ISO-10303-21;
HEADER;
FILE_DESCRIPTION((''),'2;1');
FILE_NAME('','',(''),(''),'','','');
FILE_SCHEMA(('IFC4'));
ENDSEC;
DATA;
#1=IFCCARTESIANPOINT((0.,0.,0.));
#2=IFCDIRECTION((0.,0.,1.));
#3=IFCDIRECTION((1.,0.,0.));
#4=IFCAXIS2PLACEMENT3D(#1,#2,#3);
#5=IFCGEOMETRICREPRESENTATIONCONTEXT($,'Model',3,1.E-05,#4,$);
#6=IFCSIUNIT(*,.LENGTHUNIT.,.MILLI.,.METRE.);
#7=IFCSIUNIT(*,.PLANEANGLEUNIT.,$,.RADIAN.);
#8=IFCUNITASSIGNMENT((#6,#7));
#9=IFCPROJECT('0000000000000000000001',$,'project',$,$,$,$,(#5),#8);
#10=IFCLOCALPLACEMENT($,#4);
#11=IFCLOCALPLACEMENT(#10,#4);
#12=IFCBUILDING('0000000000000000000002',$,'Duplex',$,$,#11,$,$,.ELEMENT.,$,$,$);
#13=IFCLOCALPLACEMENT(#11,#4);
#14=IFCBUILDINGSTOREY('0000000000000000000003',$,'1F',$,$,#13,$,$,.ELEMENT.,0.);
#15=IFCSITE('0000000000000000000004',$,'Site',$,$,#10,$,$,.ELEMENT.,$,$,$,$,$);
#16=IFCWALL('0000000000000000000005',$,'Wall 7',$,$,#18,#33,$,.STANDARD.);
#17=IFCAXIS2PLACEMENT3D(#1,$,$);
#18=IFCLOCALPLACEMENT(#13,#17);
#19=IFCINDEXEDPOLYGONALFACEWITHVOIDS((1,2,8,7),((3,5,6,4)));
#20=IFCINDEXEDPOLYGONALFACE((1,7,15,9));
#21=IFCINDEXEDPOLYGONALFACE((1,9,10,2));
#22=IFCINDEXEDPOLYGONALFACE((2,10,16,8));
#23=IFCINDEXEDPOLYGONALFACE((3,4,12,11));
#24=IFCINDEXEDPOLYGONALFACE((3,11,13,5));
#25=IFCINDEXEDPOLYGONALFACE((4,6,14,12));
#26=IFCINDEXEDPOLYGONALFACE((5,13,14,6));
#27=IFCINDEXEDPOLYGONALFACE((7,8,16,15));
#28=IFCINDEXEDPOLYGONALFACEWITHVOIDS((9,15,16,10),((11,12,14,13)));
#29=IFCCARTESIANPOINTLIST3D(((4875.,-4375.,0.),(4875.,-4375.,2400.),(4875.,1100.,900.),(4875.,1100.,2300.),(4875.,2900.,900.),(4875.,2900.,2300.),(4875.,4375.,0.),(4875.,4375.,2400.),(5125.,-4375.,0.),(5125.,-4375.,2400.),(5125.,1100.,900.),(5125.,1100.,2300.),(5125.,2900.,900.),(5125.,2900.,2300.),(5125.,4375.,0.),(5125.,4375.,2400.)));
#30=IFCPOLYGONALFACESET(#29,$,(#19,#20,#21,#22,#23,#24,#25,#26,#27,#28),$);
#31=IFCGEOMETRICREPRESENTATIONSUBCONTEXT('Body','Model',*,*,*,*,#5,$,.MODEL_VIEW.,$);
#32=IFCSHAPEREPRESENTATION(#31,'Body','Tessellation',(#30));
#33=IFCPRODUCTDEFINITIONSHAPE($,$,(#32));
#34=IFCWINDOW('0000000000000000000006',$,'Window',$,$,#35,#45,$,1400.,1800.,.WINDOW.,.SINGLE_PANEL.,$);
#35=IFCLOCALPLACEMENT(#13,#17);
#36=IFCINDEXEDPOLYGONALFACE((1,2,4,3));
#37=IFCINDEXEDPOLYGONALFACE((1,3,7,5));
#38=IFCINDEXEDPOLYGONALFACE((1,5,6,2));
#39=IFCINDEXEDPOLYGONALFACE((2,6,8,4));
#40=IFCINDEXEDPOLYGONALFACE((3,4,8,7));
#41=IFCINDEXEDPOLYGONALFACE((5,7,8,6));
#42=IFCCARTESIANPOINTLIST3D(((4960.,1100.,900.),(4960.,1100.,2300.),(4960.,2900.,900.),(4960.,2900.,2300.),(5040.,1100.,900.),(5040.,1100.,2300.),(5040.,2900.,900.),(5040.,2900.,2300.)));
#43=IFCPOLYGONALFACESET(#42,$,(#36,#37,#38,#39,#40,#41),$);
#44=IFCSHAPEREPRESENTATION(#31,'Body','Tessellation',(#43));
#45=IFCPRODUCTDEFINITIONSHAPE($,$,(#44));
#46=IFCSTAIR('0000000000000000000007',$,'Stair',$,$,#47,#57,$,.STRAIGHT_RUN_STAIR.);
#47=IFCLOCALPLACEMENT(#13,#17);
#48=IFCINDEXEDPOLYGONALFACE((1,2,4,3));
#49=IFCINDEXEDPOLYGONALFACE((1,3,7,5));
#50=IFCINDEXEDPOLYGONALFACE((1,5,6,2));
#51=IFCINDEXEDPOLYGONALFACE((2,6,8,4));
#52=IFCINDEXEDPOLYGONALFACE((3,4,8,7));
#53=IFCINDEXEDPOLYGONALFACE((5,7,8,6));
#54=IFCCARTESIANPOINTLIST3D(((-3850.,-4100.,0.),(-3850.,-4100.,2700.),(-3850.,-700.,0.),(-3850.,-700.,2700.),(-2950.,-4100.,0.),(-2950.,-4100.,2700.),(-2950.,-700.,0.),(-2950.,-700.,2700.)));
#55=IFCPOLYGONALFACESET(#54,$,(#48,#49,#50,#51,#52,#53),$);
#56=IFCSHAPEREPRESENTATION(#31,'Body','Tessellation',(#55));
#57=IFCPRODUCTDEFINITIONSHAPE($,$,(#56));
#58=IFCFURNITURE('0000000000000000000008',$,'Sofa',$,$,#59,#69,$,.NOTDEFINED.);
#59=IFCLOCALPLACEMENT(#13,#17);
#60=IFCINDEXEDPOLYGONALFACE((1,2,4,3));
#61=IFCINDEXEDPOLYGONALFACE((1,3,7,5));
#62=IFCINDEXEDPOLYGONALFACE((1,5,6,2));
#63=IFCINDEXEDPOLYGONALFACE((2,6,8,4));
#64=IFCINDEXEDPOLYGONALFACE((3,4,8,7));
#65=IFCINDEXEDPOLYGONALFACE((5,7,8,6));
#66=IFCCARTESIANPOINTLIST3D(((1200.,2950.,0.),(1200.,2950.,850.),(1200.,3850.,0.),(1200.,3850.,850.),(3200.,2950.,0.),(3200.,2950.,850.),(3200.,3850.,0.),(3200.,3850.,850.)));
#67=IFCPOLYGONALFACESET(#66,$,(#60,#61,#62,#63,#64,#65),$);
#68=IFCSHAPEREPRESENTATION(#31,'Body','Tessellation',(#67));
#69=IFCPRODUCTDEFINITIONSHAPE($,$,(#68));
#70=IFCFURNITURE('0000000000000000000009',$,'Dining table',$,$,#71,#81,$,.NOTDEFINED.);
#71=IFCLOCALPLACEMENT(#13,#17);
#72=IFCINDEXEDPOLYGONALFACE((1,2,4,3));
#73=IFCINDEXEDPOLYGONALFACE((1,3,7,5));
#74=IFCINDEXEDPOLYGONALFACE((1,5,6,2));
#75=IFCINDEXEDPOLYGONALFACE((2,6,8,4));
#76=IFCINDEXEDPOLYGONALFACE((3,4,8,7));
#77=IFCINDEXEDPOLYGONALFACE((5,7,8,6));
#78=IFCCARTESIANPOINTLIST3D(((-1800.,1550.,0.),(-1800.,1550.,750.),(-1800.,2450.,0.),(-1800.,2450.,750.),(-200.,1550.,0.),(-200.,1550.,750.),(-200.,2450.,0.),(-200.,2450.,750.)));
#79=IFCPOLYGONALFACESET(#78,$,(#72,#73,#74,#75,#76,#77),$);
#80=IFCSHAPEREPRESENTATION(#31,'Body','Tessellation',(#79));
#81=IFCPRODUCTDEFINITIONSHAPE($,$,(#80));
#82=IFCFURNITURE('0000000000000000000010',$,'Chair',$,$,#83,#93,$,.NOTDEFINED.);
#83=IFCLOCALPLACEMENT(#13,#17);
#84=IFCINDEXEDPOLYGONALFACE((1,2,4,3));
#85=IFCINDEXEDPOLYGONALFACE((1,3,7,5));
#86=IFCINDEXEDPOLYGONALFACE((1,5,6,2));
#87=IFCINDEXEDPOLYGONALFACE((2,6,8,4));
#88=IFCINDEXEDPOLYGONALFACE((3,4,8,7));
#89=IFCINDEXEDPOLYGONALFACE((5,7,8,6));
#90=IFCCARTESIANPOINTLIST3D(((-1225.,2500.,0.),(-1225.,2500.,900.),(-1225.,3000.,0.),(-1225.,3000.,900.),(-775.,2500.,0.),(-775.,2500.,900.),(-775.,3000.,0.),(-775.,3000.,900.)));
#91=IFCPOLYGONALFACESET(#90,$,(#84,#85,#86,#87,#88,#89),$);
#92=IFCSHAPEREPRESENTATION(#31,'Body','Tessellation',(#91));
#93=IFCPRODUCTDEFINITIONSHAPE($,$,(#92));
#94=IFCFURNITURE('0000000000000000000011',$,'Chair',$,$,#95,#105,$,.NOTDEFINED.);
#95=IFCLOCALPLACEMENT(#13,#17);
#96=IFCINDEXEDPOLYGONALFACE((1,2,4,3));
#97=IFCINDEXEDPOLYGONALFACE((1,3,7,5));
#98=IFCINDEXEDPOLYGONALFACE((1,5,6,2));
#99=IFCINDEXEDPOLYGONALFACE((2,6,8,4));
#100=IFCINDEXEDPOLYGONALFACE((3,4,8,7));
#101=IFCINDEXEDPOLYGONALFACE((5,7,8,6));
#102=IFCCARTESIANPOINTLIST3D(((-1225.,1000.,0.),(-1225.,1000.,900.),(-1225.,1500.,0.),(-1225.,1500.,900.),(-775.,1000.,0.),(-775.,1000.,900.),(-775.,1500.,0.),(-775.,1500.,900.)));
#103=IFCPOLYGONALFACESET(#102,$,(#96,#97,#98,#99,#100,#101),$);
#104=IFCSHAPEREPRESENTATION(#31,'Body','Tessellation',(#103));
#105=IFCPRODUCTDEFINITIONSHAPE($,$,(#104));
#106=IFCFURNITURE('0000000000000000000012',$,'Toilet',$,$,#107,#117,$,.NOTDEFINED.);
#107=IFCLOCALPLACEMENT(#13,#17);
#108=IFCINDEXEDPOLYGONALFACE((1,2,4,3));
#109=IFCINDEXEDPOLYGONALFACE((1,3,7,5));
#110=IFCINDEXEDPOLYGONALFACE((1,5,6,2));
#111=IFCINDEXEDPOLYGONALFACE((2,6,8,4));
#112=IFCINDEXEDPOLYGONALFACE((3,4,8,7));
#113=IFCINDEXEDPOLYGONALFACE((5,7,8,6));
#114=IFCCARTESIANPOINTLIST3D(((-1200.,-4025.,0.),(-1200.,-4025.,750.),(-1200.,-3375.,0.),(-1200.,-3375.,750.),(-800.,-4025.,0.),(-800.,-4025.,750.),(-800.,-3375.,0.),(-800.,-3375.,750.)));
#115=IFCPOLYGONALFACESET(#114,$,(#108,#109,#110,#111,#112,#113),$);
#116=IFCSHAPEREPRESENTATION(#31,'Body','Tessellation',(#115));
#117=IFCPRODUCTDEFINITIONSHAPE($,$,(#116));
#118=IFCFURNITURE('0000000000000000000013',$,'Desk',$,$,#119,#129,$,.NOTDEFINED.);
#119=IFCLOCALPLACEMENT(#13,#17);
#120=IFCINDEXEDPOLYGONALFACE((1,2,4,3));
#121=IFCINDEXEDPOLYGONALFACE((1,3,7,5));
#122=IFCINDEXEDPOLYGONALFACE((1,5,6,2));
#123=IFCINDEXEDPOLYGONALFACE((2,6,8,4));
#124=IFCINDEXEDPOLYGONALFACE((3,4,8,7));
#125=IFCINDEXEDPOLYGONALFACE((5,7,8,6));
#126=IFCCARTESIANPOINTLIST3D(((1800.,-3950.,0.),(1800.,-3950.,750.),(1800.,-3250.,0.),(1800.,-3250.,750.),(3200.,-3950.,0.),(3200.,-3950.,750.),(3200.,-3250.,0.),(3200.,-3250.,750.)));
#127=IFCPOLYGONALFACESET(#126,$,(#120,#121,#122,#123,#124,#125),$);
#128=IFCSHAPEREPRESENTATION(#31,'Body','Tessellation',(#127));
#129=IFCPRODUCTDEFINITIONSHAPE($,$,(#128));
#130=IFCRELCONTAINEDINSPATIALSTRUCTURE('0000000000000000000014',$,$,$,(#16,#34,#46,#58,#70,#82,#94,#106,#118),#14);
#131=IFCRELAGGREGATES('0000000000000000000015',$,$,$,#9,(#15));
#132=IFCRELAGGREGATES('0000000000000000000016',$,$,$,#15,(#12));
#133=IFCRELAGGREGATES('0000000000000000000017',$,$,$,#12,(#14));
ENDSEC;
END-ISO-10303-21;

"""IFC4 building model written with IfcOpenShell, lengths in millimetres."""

from ifc_helpers import new_model, si_unit, frame, frame_2d, origin, origin_with_axes, origin_2d, place, context, subcontext, project, spatial, rectangle, extrude, element, fill, save


model = new_model("IFC4")

# Units and contexts
model_context = context("Model", 3, precision=1e-05, world=origin_with_axes())
body_context = subcontext(model_context, "Body", "Model", "MODEL_VIEW")
ifc_project = project(units=[si_unit("LENGTHUNIT", "METRE", prefix="MILLI"), si_unit("PLANEANGLEUNIT", "RADIAN")], contexts=[model_context])

# Site, building, storey
site_placement = place(None, origin_with_axes())
site = spatial("IfcSite", under=ifc_project, at=site_placement, Name="Site", CompositionType="ELEMENT")
building_placement = place(site_placement, origin_with_axes())
building = spatial("IfcBuilding", under=site, at=building_placement, Name="Duplex", CompositionType="ELEMENT")
storey_placement = place(building_placement, origin_with_axes())
storey = spatial("IfcBuildingStorey", under=building, at=storey_placement, Name="1F", CompositionType="ELEMENT", Elevation=0.0)

# Wall, opening, window
wall_1_placement = place(storey_placement, frame((5000.0, 4250.0, 0.0), z_axis=(0.0, 0.0, 1.0), x_axis=(0.0, -1.0, 0.0)))
wall_1 = element("IfcWall", 1, at=wall_1_placement, inside=storey, Name="Wall 7", PredefinedType="STANDARD", context=body_context, shape_type="SweptSolid", body=[
    extrude(rectangle(XDim=8750.0, YDim=250.0, at=frame_2d((4250.0, 0.0))), origin(), (0.0, 0.0, 1.0), 2400.0),
])
opening_1_placement = place(wall_1_placement, frame((1350.0, 0.0, 900.0), z_axis=(0.0, 0.0, 1.0), x_axis=(1.0, 0.0, 0.0)))
opening_1 = element("IfcOpeningElement", 2, at=opening_1_placement, cuts=wall_1, PredefinedType="OPENING", context=body_context, shape_type="SweptSolid", body=[
    extrude(rectangle(XDim=1800.0, YDim=350.0, at=frame_2d((900.0, 0.0))), origin(), (0.0, 0.0, 1.0), 1400.0),
])
window_1_placement = place(opening_1_placement, origin_with_axes())
window_1 = element("IfcWindow", 3, at=window_1_placement, inside=storey, Name="Window", OverallHeight=1400.0, OverallWidth=1800.0, PartitioningType="SINGLE_PANEL", PredefinedType="WINDOW", context=body_context, shape_type="SweptSolid", body=[
    extrude(rectangle(XDim=1800.0, YDim=80.0, at=frame_2d((900.0, 0.0))), origin(), (0.0, 0.0, 1.0), 1400.0),
])
fill(opening_1, window_1)

# Stair
stair_placement = place(storey_placement, frame((-3400.0, -2400.0, 0.0), z_axis=(0.0, 0.0, 1.0), x_axis=(1.0, 0.0, 0.0)))
element("IfcStair", 4, at=stair_placement, inside=storey, Name="Stair", PredefinedType="STRAIGHT_RUN_STAIR", context=body_context, shape_type="SweptSolid", body=[
    extrude(rectangle(XDim=900.0, YDim=3400.0, at=origin_2d()), origin(), (0.0, 0.0, 1.0), 2700.0),
])

# Furniture
furniture_1_placement = place(storey_placement, frame((2200.0, 3400.0, 0.0), z_axis=(0.0, 0.0, 1.0), x_axis=(1.0, 0.0, 0.0)))
element("IfcFurniture", 5, at=furniture_1_placement, inside=storey, Name="Sofa", PredefinedType="NOTDEFINED", context=body_context, shape_type="SweptSolid", body=[
    extrude(rectangle(XDim=2000.0, YDim=900.0, at=origin_2d()), origin(), (0.0, 0.0, 1.0), 850.0),
])
furniture_2_placement = place(storey_placement, frame((-1000.0, 2000.0, 0.0), z_axis=(0.0, 0.0, 1.0), x_axis=(1.0, 0.0, 0.0)))
element("IfcFurniture", 6, at=furniture_2_placement, inside=storey, Name="Dining table", PredefinedType="NOTDEFINED", context=body_context, shape_type="SweptSolid", body=[
    extrude(rectangle(XDim=1600.0, YDim=900.0, at=origin_2d()), origin(), (0.0, 0.0, 1.0), 750.0),
])
for number, where, z_axis, x_axis, name in (
    (7, (-1000.0, 2750.0, 0.0), (0.0, 0.0, 1.0), (-1.0, 0.0, 0.0), "Chair"),
    (8, (-1000.0, 1250.0, 0.0), (0.0, 0.0, 1.0), (1.0, 0.0, 0.0), "Chair"),
):
    element("IfcFurniture", number, at=place(storey_placement, frame(where, z_axis=z_axis, x_axis=x_axis)), inside=storey, Name=name, PredefinedType="NOTDEFINED", context=body_context, shape_type="SweptSolid", body=[
        extrude(rectangle(XDim=450.0, YDim=500.0, at=origin_2d()), origin(), (0.0, 0.0, 1.0), 900.0),
    ])
furniture_3_placement = place(storey_placement, frame((-1000.0, -3700.0, 0.0), z_axis=(0.0, 0.0, 1.0), x_axis=(-1.0, 0.0, 0.0)))
element("IfcFurniture", 9, at=furniture_3_placement, inside=storey, Name="Toilet", PredefinedType="NOTDEFINED", context=body_context, shape_type="SweptSolid", body=[
    extrude(rectangle(XDim=400.0, YDim=650.0, at=origin_2d()), origin(), (0.0, 0.0, 1.0), 750.0),
])
furniture_4_placement = place(storey_placement, frame((2500.0, -3600.0, 0.0), z_axis=(0.0, 0.0, 1.0), x_axis=(-1.0, 0.0, 0.0)))
element("IfcFurniture", 10, at=furniture_4_placement, inside=storey, Name="Desk", PredefinedType="NOTDEFINED", context=body_context, shape_type="SweptSolid", body=[
    extrude(rectangle(XDim=1400.0, YDim=700.0, at=origin_2d()), origin(), (0.0, 0.0, 1.0), 750.0),
])

save(model, "model.ifc")
